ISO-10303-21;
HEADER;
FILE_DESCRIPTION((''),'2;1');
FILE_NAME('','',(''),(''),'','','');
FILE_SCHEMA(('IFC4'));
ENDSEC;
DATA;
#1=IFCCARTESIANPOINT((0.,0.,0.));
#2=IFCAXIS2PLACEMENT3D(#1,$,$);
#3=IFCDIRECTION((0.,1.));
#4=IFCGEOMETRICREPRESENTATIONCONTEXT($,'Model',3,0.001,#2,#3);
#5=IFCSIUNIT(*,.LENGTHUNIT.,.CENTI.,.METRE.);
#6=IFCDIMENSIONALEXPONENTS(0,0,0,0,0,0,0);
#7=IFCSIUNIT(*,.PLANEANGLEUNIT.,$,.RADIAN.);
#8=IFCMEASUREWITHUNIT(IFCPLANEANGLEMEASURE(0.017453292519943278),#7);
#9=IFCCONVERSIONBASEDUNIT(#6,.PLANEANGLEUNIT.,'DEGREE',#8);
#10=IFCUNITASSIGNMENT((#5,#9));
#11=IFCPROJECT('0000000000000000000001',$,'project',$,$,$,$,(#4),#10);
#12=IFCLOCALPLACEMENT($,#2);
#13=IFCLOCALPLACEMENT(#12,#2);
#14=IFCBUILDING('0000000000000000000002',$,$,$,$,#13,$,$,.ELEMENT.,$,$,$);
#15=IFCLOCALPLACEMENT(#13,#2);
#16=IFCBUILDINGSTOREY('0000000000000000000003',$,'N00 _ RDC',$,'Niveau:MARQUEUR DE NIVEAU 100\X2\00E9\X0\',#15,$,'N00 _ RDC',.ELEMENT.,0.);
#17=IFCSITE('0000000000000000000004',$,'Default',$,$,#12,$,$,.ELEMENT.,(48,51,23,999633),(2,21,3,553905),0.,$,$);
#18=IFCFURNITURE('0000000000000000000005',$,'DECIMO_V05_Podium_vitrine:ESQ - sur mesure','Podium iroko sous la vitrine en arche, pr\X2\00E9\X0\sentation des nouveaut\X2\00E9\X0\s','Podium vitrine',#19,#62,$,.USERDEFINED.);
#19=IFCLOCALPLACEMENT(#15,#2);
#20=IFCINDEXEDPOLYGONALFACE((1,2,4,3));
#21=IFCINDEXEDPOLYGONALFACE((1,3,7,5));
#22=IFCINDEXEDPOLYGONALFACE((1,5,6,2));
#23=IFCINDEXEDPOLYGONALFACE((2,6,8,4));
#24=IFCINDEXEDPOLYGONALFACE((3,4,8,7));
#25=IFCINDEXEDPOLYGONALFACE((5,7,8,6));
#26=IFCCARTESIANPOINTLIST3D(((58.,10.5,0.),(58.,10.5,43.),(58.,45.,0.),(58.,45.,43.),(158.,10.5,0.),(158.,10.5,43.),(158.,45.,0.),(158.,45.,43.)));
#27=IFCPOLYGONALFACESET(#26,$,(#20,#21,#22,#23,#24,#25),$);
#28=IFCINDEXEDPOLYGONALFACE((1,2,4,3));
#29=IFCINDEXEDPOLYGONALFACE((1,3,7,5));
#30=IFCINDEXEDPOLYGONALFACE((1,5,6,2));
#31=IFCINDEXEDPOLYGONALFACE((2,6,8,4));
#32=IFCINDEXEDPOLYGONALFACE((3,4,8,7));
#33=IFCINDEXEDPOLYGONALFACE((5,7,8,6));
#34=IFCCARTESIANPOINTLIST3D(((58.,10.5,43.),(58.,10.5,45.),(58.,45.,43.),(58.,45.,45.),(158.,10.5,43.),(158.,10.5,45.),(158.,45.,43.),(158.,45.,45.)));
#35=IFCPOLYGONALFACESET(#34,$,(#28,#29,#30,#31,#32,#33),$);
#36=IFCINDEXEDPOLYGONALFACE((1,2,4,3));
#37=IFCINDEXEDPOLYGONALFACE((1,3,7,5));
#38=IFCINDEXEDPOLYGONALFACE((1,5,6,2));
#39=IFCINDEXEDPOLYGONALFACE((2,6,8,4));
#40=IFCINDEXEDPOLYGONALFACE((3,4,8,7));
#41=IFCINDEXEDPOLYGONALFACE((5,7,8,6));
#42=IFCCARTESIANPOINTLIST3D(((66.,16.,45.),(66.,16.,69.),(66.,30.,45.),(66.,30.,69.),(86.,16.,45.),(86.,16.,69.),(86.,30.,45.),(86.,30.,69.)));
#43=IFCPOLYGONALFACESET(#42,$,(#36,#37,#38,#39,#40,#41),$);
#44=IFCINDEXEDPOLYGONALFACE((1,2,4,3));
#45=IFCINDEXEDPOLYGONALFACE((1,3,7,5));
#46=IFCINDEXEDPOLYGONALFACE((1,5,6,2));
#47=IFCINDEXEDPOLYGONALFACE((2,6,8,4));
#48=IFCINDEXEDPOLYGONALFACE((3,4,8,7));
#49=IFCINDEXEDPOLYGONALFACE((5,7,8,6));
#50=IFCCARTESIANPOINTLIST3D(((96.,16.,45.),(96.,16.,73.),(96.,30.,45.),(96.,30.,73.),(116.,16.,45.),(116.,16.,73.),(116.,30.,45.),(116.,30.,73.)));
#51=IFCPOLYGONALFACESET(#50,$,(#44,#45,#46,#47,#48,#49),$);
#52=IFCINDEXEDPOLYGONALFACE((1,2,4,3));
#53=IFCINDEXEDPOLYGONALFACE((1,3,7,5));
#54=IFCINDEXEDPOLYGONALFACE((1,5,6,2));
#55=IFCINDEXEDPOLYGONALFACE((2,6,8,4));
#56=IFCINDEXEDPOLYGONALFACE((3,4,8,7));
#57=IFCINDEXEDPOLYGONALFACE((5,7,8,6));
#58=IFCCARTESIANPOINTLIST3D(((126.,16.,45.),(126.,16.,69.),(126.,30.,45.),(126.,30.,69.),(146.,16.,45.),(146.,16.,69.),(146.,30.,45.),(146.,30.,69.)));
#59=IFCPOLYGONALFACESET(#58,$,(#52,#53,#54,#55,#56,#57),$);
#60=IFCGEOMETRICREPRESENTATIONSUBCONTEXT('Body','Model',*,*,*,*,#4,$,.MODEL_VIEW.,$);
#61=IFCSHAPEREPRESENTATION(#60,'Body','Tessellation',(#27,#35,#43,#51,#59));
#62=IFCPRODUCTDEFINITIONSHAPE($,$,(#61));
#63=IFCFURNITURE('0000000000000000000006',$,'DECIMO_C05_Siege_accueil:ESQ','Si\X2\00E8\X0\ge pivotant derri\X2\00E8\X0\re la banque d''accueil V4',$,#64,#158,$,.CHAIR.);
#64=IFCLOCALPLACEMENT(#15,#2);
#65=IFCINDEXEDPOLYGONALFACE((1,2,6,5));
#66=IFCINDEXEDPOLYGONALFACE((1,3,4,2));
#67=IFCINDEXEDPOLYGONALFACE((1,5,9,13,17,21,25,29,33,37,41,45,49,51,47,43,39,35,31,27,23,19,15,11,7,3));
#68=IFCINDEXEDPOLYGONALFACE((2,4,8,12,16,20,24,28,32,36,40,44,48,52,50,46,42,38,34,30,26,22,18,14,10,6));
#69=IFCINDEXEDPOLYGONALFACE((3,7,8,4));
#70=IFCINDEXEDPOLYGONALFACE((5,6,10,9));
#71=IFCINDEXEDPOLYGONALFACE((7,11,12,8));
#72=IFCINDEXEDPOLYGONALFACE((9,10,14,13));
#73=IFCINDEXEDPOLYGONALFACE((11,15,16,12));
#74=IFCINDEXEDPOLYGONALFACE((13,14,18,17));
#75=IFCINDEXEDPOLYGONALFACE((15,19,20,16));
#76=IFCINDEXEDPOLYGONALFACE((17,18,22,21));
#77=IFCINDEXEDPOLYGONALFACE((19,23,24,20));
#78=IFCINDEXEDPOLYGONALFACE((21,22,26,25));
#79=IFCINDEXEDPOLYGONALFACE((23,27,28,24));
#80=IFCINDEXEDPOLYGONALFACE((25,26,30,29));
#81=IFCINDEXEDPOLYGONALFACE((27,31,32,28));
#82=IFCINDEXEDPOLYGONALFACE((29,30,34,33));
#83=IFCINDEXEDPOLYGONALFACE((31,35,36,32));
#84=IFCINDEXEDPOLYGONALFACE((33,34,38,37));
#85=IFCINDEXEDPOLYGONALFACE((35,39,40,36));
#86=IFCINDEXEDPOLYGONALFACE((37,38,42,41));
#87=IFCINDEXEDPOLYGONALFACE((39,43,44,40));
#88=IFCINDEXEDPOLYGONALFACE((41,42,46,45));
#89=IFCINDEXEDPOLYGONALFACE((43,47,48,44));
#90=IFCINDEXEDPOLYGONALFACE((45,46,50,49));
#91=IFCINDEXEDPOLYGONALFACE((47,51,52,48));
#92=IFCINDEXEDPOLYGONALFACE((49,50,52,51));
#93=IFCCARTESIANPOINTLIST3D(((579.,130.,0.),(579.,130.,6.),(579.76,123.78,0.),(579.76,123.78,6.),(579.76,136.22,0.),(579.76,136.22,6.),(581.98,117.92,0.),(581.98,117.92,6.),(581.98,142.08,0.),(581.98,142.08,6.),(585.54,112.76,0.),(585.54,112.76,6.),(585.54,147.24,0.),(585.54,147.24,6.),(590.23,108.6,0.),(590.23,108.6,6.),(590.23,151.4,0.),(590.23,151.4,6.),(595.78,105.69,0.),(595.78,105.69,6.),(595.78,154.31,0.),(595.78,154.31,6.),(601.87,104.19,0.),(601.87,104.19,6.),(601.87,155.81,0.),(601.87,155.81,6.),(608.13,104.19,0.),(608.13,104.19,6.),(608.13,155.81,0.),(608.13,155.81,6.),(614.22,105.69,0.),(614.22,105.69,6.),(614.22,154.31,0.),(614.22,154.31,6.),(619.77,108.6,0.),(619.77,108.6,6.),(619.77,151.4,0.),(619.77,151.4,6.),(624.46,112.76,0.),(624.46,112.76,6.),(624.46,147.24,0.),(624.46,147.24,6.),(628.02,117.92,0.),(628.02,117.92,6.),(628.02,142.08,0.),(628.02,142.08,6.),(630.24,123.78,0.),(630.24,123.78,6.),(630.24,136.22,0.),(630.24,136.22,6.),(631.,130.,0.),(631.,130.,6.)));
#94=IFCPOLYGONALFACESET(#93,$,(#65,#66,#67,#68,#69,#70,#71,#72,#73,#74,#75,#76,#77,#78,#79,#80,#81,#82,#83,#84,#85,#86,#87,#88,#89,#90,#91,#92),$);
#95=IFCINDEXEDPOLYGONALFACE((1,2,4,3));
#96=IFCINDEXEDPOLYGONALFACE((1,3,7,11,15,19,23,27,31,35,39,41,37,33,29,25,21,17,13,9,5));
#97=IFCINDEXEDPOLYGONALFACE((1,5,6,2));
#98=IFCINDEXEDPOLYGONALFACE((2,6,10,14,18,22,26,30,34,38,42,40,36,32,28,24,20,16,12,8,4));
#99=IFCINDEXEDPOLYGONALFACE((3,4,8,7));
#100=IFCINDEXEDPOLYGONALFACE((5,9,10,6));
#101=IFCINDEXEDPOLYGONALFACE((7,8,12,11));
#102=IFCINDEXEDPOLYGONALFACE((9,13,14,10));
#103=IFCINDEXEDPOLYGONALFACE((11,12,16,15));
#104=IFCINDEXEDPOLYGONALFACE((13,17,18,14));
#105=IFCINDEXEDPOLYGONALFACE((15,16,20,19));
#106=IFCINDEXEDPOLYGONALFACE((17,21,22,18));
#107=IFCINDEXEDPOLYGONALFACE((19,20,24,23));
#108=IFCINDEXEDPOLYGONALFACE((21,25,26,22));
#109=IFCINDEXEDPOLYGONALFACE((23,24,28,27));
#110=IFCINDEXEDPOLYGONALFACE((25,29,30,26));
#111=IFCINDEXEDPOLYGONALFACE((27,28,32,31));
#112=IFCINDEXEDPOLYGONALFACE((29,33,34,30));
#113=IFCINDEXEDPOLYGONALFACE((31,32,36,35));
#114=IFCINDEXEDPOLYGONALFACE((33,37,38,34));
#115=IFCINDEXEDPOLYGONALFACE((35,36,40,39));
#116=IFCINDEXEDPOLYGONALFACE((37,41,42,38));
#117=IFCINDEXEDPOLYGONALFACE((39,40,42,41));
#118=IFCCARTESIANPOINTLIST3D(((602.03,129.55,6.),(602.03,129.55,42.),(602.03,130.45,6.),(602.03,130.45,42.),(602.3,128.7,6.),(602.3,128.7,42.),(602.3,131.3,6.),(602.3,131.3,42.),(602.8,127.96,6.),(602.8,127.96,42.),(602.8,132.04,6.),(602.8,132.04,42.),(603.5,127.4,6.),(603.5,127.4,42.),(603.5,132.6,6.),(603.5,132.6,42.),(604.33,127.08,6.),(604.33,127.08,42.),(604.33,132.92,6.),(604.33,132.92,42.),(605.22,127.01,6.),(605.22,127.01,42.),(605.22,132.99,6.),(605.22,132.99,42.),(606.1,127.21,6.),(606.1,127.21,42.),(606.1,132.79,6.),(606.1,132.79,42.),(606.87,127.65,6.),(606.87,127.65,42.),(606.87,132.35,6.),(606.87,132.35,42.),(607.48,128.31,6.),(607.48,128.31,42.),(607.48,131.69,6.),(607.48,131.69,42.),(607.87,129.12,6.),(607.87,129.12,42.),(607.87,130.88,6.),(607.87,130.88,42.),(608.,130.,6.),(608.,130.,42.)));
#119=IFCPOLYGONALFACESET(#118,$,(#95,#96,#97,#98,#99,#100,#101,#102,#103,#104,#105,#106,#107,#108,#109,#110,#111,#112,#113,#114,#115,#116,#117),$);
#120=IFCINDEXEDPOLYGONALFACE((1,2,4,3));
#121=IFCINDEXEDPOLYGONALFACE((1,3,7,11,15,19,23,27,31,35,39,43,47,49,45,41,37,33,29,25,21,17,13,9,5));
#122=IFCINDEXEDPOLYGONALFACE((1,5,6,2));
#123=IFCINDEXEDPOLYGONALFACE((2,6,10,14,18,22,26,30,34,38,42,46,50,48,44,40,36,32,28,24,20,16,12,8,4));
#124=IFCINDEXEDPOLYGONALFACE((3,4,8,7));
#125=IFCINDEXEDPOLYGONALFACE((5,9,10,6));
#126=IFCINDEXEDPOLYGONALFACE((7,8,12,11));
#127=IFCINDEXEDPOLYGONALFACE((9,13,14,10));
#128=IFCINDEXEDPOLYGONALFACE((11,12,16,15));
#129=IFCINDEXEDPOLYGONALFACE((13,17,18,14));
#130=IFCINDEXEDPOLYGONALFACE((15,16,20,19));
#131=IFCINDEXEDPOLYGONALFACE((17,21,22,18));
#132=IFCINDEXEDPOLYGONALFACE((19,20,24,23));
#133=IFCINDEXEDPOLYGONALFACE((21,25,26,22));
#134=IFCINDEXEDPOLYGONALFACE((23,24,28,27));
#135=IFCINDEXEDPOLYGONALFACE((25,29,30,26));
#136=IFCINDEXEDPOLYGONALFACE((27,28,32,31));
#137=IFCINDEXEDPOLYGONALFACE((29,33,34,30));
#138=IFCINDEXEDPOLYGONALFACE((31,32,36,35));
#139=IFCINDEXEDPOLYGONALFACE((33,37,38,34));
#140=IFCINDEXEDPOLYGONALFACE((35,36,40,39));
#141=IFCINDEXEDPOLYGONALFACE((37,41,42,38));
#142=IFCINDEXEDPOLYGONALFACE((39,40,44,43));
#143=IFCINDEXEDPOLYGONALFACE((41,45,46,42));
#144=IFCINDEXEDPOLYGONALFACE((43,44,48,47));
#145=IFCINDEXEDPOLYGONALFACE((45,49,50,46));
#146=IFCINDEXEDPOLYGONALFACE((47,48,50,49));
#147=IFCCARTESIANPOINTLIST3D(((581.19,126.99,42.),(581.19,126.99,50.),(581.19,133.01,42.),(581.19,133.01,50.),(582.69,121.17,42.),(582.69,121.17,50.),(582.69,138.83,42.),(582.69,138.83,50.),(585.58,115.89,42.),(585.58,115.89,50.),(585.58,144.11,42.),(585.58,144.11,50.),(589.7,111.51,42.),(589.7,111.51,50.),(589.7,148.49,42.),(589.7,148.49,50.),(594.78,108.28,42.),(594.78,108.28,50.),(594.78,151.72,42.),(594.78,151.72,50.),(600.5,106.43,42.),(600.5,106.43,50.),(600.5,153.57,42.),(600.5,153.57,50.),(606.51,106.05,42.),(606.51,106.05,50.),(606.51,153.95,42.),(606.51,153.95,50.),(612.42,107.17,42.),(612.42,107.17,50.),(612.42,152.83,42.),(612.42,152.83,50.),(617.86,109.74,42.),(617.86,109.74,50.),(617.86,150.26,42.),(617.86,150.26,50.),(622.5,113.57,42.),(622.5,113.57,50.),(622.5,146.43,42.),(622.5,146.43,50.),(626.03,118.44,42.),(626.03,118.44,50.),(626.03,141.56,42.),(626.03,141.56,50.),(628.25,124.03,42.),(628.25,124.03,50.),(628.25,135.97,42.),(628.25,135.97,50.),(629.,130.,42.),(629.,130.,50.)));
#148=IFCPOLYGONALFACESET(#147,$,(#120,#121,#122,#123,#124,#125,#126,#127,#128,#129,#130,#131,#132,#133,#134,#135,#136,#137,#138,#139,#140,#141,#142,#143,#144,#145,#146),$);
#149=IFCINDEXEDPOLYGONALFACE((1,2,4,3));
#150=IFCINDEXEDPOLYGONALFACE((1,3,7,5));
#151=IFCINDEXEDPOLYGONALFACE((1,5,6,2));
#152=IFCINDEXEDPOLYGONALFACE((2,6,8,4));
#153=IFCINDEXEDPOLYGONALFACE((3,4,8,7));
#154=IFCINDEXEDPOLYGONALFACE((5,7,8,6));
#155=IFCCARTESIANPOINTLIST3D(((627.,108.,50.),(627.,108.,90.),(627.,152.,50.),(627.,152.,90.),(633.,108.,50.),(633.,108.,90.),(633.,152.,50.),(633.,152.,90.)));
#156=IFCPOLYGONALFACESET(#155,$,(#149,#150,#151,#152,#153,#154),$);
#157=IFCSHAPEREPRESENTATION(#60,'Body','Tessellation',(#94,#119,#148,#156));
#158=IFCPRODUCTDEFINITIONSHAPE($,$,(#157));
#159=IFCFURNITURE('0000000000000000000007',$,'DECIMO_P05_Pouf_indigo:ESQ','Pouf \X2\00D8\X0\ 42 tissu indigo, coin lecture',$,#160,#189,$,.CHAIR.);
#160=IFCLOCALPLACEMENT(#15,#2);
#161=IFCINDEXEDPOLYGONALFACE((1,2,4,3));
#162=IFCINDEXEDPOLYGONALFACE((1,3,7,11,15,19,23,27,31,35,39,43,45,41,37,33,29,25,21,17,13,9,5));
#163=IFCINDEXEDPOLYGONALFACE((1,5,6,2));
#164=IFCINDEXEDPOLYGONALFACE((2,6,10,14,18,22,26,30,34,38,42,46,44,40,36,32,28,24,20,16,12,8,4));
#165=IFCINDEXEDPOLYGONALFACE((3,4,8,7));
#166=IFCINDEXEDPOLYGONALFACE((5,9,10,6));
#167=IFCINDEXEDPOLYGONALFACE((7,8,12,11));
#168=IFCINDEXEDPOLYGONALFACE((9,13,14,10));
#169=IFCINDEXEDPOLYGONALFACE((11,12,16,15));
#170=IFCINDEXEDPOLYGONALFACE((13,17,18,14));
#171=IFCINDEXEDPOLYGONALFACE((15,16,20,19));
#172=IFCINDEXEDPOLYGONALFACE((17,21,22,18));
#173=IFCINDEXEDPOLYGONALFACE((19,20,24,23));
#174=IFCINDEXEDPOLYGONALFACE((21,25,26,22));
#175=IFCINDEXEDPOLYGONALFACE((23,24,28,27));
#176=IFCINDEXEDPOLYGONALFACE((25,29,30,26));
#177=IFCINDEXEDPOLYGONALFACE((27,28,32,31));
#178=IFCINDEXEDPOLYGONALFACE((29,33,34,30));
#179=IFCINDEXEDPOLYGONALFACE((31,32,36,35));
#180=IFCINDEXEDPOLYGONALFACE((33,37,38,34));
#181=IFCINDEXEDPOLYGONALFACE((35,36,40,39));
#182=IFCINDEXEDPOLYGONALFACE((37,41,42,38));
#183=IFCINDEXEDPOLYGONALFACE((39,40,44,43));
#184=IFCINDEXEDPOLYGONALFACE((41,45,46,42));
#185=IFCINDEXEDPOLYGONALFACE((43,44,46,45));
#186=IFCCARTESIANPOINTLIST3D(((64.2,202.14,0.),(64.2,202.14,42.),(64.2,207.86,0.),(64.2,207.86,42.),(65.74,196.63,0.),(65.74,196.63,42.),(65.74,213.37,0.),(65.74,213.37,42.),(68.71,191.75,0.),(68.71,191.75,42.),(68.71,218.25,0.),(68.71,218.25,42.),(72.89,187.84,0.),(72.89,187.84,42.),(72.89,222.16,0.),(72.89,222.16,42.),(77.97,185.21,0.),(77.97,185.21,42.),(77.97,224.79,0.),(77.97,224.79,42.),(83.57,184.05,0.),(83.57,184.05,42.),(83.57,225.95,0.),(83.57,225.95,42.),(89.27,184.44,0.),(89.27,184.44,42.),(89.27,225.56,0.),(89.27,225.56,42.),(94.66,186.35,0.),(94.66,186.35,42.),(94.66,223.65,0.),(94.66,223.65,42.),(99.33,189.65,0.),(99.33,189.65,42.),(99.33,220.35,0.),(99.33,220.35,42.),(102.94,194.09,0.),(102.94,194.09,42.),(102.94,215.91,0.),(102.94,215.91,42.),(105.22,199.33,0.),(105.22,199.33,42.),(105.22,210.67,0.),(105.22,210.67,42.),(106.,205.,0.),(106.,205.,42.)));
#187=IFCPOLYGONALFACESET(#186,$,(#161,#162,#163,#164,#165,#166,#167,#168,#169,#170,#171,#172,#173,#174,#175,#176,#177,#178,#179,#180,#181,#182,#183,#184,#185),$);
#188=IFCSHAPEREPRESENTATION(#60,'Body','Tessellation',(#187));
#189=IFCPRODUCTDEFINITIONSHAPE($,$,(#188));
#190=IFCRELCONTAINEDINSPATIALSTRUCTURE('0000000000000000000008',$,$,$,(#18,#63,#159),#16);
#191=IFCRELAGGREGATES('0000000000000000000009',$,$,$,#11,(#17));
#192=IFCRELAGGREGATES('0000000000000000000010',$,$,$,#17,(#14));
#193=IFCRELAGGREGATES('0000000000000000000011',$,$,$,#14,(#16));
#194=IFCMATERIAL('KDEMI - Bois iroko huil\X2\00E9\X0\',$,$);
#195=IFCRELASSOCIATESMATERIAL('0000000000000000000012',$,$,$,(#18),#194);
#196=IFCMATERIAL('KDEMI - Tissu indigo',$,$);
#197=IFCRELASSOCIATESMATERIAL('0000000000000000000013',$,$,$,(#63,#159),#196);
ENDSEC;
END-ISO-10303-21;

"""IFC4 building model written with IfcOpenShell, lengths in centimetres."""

from ifc_helpers import new_model, entity, si_unit, converted_unit, direction, frame, frame_2d, origin, origin_with_axes, place, context, subcontext, project, spatial, rectangle, circle, extrude, material, element, save


model = new_model("IFC4")

# Units and contexts
model_context = context("Model", 3, precision=0.001, world=origin(), true_north=direction((0.0, 1.0)))
body_context = subcontext(model_context, "Body", "Model", "MODEL_VIEW")
ifc_project = project(units=[si_unit("LENGTHUNIT", "METRE", prefix="CENTI"), converted_unit("PLANEANGLEUNIT", "DEGREE", entity("IfcPlaneAngleMeasure", 0.017453292519943278), si_unit("PLANEANGLEUNIT", "RADIAN"), dimensions=[0, 0, 0, 0, 0, 0, 0])], contexts=[model_context])

# Site, building, storey
site_placement = place(None, origin())
site = spatial("IfcSite", under=ifc_project, at=site_placement, Name="Default", CompositionType="ELEMENT", RefLatitude=(48, 51, 23, 999633), RefLongitude=(2, 21, 3, 553905), RefElevation=0.0)
building_placement = place(site_placement, origin())
building = spatial("IfcBuilding", under=site, at=building_placement, CompositionType="ELEMENT")
storey_placement = place(building_placement, origin())
storey = spatial("IfcBuildingStorey", under=building, at=storey_placement, Name="N00 _ RDC", ObjectType="Niveau:MARQUEUR DE NIVEAU 100é", LongName="N00 _ RDC", CompositionType="ELEMENT", Elevation=0.0)

# Furniture
ifc_material_1 = material(Name="KDEMI - Bois iroko huilé")
furniture_1_placement = place(storey_placement, origin_with_axes())
element("IfcFurniture", 1, at=furniture_1_placement, inside=storey, material=ifc_material_1, Name="DECIMO_V05_Podium_vitrine:ESQ - sur mesure", Description="Podium iroko sous la vitrine en arche, présentation des nouveautés", ObjectType="Podium vitrine", PredefinedType="USERDEFINED", context=body_context, shape_type="SweptSolid", body=[
    extrude(rectangle(XDim=100.0, YDim=34.5, at=frame_2d((108.0, 27.75))), origin(), (0.0, 0.0, 1.0), 43.0),
    extrude(rectangle(XDim=100.0, YDim=34.5, at=frame_2d((108.0, 27.75))), frame((0.0, 0.0, 43.0)), (0.0, 0.0, 1.0), 2.0),
    extrude(rectangle(XDim=20.0, YDim=14.0, at=frame_2d((76.0, 23.0))), frame((0.0, 0.0, 45.0)), (0.0, 0.0, 1.0), 24.0),
    extrude(rectangle(XDim=20.0, YDim=14.0, at=frame_2d((106.0, 23.0))), frame((0.0, 0.0, 45.0)), (0.0, 0.0, 1.0), 28.0),
    extrude(rectangle(XDim=20.0, YDim=14.0, at=frame_2d((136.0, 23.0))), frame((0.0, 0.0, 45.0)), (0.0, 0.0, 1.0), 24.0),
])
ifc_material_2 = material(Name="KDEMI - Tissu indigo")
furniture_2_placement = place(storey_placement, origin_with_axes())
element("IfcFurniture", 2, at=furniture_2_placement, inside=storey, material=ifc_material_2, Name="DECIMO_C05_Siege_accueil:ESQ", Description="Siège pivotant derrière la banque d'accueil V4", PredefinedType="CHAIR", context=body_context, shape_type="SweptSolid", body=[
    extrude(circle(Radius=26.0, at=frame_2d((605.0, 130.0))), origin(), (0.0, 0.0, 1.0), 6.0),
    extrude(circle(Radius=3.0, at=frame_2d((605.0, 130.0))), frame((0.0, 0.0, 6.0)), (0.0, 0.0, 1.0), 36.0),
    extrude(circle(Radius=24.0, at=frame_2d((605.0, 130.0))), frame((0.0, 0.0, 42.0)), (0.0, 0.0, 1.0), 8.0),
    extrude(rectangle(XDim=6.0, YDim=44.0, at=frame_2d((630.0, 130.0))), frame((0.0, 0.0, 50.0)), (0.0, 0.0, 1.0), 40.0),
])
furniture_3_placement = place(storey_placement, origin_with_axes())
element("IfcFurniture", 3, at=furniture_3_placement, inside=storey, material=ifc_material_2, Name="DECIMO_P05_Pouf_indigo:ESQ", Description="Pouf Ø 42 tissu indigo, coin lecture", PredefinedType="CHAIR", context=body_context, shape_type="SweptSolid", body=[
    extrude(circle(Radius=21.0, at=frame_2d((85.0, 205.0))), origin(), (0.0, 0.0, 1.0), 42.0),
])

save(model, "model.ifc")
